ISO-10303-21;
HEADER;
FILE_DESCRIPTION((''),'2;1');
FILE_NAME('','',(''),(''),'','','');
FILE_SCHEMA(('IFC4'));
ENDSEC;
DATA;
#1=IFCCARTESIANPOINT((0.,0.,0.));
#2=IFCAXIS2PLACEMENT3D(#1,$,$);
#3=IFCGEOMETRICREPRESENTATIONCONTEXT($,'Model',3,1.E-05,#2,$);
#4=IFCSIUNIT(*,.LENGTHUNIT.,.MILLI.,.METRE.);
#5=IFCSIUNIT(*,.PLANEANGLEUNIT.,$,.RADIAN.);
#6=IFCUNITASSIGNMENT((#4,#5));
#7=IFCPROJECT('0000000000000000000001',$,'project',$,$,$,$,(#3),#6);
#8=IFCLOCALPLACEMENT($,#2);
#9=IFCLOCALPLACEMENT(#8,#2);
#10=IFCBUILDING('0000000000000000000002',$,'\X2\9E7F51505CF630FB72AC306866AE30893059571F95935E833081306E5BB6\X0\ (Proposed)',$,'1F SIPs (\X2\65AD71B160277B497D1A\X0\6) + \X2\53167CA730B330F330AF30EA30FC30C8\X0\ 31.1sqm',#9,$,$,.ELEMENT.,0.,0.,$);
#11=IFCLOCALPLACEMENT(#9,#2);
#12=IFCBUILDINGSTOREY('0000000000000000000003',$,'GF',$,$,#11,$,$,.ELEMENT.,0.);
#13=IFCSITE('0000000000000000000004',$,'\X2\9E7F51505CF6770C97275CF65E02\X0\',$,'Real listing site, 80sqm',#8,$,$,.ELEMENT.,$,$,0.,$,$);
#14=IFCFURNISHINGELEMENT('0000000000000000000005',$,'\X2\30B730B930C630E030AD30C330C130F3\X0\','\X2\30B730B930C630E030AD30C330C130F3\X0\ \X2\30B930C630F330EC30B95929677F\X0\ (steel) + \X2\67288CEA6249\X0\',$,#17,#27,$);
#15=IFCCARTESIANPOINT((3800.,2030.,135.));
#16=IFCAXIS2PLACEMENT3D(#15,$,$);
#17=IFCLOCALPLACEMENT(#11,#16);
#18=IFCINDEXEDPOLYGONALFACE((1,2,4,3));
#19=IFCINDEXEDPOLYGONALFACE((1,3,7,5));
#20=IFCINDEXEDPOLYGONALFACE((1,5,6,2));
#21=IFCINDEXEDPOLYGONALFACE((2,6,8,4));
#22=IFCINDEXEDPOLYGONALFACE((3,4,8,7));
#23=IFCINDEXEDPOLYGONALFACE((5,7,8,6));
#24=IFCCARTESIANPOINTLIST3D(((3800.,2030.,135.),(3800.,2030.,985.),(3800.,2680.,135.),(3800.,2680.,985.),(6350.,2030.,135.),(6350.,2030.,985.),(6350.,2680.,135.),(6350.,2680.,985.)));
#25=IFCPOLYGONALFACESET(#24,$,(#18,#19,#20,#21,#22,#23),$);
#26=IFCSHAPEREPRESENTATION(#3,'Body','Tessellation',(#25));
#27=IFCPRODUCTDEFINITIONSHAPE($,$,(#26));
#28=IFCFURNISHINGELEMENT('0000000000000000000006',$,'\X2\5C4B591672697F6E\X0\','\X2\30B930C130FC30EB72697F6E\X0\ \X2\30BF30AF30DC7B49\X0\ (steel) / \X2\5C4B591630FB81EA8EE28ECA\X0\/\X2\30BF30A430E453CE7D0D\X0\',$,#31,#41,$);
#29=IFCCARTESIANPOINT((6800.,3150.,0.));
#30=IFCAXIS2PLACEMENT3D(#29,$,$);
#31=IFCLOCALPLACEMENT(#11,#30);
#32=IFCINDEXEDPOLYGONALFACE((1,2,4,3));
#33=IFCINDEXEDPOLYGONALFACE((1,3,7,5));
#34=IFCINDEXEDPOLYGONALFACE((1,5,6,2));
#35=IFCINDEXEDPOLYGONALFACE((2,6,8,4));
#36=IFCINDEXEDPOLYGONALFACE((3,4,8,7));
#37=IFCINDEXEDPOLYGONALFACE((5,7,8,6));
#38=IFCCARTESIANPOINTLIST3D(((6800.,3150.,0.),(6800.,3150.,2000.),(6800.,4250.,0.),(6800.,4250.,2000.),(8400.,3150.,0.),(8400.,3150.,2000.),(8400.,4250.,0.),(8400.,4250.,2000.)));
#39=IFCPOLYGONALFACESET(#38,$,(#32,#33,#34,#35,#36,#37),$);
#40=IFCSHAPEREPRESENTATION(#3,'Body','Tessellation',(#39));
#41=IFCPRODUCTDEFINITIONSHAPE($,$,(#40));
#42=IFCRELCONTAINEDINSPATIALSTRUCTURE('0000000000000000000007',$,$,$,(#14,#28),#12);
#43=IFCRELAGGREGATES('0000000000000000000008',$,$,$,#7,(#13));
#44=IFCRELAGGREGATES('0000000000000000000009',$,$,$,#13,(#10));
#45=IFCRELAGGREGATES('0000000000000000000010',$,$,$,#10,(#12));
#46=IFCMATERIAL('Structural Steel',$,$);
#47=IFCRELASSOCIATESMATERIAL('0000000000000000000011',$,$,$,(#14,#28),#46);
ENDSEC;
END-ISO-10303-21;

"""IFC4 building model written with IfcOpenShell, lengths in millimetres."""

from ifc_helpers import new_model, si_unit, frame, frame_2d, origin, place, context, project, spatial, rectangle, extrude, material, element, save


model = new_model("IFC4")

# Units and contexts
model_context = context("Model", 3, precision=1e-05, world=origin())
ifc_project = project(units=[si_unit("LENGTHUNIT", "METRE", prefix="MILLI"), si_unit("PLANEANGLEUNIT", "RADIAN")], contexts=[model_context])

# Site, building, storey
site_placement = place(None, origin())
site = spatial("IfcSite", under=ifc_project, at=site_placement, Name="鹿児島県霧島市", ObjectType="Real listing site, 80sqm", CompositionType="ELEMENT", RefElevation=0.0)
building_placement = place(site_placement, origin())
building = spatial("IfcBuilding", under=site, at=building_placement, Name="鹿児島・犬と暮らす土間広めの家 (Proposed)", ObjectType="1F SIPs (断熱性等級6) + 化粧コンクリート 31.1sqm", CompositionType="ELEMENT", ElevationOfRefHeight=0.0, ElevationOfTerrain=0.0)
storey_placement = place(building_placement, origin())
storey = spatial("IfcBuildingStorey", under=building, at=storey_placement, Name="GF", CompositionType="ELEMENT", Elevation=0.0)

# Shared definitions
ifc_material_1 = material(Name="Structural Steel")

# Furnishing elements
furnishing_1_placement = place(storey_placement, frame((3800.0, 2030.0, 135.0)))
element("IfcFurnishingElement", 1, at=furnishing_1_placement, inside=storey, material=ifc_material_1, Name="システムキッチン", Description="システムキッチン ステンレス天板 (steel) + 木質扉", context=model_context, shape_type="SweptSolid", body=[
    extrude(rectangle(XDim=2550.0, YDim=650.0, at=frame_2d((1275.0, 325.0))), frame((3800.0, 2030.0, 135.0)), (0.0, 0.0, 1.0), 850.0),
])
furnishing_2_placement = place(storey_placement, frame((6800.0, 3150.0, 0.0)))
element("IfcFurnishingElement", 2, at=furnishing_2_placement, inside=storey, material=ifc_material_1, Name="屋外物置", Description="スチール物置 タクボ等 (steel) / 屋外・自転車/タイヤ収納", context=model_context, shape_type="SweptSolid", body=[
    extrude(rectangle(XDim=1600.0, YDim=1100.0, at=frame_2d((800.0, 550.0))), frame((6800.0, 3150.0, 0.0)), (0.0, 0.0, 1.0), 2000.0),
])

save(model, "model.ifc")
